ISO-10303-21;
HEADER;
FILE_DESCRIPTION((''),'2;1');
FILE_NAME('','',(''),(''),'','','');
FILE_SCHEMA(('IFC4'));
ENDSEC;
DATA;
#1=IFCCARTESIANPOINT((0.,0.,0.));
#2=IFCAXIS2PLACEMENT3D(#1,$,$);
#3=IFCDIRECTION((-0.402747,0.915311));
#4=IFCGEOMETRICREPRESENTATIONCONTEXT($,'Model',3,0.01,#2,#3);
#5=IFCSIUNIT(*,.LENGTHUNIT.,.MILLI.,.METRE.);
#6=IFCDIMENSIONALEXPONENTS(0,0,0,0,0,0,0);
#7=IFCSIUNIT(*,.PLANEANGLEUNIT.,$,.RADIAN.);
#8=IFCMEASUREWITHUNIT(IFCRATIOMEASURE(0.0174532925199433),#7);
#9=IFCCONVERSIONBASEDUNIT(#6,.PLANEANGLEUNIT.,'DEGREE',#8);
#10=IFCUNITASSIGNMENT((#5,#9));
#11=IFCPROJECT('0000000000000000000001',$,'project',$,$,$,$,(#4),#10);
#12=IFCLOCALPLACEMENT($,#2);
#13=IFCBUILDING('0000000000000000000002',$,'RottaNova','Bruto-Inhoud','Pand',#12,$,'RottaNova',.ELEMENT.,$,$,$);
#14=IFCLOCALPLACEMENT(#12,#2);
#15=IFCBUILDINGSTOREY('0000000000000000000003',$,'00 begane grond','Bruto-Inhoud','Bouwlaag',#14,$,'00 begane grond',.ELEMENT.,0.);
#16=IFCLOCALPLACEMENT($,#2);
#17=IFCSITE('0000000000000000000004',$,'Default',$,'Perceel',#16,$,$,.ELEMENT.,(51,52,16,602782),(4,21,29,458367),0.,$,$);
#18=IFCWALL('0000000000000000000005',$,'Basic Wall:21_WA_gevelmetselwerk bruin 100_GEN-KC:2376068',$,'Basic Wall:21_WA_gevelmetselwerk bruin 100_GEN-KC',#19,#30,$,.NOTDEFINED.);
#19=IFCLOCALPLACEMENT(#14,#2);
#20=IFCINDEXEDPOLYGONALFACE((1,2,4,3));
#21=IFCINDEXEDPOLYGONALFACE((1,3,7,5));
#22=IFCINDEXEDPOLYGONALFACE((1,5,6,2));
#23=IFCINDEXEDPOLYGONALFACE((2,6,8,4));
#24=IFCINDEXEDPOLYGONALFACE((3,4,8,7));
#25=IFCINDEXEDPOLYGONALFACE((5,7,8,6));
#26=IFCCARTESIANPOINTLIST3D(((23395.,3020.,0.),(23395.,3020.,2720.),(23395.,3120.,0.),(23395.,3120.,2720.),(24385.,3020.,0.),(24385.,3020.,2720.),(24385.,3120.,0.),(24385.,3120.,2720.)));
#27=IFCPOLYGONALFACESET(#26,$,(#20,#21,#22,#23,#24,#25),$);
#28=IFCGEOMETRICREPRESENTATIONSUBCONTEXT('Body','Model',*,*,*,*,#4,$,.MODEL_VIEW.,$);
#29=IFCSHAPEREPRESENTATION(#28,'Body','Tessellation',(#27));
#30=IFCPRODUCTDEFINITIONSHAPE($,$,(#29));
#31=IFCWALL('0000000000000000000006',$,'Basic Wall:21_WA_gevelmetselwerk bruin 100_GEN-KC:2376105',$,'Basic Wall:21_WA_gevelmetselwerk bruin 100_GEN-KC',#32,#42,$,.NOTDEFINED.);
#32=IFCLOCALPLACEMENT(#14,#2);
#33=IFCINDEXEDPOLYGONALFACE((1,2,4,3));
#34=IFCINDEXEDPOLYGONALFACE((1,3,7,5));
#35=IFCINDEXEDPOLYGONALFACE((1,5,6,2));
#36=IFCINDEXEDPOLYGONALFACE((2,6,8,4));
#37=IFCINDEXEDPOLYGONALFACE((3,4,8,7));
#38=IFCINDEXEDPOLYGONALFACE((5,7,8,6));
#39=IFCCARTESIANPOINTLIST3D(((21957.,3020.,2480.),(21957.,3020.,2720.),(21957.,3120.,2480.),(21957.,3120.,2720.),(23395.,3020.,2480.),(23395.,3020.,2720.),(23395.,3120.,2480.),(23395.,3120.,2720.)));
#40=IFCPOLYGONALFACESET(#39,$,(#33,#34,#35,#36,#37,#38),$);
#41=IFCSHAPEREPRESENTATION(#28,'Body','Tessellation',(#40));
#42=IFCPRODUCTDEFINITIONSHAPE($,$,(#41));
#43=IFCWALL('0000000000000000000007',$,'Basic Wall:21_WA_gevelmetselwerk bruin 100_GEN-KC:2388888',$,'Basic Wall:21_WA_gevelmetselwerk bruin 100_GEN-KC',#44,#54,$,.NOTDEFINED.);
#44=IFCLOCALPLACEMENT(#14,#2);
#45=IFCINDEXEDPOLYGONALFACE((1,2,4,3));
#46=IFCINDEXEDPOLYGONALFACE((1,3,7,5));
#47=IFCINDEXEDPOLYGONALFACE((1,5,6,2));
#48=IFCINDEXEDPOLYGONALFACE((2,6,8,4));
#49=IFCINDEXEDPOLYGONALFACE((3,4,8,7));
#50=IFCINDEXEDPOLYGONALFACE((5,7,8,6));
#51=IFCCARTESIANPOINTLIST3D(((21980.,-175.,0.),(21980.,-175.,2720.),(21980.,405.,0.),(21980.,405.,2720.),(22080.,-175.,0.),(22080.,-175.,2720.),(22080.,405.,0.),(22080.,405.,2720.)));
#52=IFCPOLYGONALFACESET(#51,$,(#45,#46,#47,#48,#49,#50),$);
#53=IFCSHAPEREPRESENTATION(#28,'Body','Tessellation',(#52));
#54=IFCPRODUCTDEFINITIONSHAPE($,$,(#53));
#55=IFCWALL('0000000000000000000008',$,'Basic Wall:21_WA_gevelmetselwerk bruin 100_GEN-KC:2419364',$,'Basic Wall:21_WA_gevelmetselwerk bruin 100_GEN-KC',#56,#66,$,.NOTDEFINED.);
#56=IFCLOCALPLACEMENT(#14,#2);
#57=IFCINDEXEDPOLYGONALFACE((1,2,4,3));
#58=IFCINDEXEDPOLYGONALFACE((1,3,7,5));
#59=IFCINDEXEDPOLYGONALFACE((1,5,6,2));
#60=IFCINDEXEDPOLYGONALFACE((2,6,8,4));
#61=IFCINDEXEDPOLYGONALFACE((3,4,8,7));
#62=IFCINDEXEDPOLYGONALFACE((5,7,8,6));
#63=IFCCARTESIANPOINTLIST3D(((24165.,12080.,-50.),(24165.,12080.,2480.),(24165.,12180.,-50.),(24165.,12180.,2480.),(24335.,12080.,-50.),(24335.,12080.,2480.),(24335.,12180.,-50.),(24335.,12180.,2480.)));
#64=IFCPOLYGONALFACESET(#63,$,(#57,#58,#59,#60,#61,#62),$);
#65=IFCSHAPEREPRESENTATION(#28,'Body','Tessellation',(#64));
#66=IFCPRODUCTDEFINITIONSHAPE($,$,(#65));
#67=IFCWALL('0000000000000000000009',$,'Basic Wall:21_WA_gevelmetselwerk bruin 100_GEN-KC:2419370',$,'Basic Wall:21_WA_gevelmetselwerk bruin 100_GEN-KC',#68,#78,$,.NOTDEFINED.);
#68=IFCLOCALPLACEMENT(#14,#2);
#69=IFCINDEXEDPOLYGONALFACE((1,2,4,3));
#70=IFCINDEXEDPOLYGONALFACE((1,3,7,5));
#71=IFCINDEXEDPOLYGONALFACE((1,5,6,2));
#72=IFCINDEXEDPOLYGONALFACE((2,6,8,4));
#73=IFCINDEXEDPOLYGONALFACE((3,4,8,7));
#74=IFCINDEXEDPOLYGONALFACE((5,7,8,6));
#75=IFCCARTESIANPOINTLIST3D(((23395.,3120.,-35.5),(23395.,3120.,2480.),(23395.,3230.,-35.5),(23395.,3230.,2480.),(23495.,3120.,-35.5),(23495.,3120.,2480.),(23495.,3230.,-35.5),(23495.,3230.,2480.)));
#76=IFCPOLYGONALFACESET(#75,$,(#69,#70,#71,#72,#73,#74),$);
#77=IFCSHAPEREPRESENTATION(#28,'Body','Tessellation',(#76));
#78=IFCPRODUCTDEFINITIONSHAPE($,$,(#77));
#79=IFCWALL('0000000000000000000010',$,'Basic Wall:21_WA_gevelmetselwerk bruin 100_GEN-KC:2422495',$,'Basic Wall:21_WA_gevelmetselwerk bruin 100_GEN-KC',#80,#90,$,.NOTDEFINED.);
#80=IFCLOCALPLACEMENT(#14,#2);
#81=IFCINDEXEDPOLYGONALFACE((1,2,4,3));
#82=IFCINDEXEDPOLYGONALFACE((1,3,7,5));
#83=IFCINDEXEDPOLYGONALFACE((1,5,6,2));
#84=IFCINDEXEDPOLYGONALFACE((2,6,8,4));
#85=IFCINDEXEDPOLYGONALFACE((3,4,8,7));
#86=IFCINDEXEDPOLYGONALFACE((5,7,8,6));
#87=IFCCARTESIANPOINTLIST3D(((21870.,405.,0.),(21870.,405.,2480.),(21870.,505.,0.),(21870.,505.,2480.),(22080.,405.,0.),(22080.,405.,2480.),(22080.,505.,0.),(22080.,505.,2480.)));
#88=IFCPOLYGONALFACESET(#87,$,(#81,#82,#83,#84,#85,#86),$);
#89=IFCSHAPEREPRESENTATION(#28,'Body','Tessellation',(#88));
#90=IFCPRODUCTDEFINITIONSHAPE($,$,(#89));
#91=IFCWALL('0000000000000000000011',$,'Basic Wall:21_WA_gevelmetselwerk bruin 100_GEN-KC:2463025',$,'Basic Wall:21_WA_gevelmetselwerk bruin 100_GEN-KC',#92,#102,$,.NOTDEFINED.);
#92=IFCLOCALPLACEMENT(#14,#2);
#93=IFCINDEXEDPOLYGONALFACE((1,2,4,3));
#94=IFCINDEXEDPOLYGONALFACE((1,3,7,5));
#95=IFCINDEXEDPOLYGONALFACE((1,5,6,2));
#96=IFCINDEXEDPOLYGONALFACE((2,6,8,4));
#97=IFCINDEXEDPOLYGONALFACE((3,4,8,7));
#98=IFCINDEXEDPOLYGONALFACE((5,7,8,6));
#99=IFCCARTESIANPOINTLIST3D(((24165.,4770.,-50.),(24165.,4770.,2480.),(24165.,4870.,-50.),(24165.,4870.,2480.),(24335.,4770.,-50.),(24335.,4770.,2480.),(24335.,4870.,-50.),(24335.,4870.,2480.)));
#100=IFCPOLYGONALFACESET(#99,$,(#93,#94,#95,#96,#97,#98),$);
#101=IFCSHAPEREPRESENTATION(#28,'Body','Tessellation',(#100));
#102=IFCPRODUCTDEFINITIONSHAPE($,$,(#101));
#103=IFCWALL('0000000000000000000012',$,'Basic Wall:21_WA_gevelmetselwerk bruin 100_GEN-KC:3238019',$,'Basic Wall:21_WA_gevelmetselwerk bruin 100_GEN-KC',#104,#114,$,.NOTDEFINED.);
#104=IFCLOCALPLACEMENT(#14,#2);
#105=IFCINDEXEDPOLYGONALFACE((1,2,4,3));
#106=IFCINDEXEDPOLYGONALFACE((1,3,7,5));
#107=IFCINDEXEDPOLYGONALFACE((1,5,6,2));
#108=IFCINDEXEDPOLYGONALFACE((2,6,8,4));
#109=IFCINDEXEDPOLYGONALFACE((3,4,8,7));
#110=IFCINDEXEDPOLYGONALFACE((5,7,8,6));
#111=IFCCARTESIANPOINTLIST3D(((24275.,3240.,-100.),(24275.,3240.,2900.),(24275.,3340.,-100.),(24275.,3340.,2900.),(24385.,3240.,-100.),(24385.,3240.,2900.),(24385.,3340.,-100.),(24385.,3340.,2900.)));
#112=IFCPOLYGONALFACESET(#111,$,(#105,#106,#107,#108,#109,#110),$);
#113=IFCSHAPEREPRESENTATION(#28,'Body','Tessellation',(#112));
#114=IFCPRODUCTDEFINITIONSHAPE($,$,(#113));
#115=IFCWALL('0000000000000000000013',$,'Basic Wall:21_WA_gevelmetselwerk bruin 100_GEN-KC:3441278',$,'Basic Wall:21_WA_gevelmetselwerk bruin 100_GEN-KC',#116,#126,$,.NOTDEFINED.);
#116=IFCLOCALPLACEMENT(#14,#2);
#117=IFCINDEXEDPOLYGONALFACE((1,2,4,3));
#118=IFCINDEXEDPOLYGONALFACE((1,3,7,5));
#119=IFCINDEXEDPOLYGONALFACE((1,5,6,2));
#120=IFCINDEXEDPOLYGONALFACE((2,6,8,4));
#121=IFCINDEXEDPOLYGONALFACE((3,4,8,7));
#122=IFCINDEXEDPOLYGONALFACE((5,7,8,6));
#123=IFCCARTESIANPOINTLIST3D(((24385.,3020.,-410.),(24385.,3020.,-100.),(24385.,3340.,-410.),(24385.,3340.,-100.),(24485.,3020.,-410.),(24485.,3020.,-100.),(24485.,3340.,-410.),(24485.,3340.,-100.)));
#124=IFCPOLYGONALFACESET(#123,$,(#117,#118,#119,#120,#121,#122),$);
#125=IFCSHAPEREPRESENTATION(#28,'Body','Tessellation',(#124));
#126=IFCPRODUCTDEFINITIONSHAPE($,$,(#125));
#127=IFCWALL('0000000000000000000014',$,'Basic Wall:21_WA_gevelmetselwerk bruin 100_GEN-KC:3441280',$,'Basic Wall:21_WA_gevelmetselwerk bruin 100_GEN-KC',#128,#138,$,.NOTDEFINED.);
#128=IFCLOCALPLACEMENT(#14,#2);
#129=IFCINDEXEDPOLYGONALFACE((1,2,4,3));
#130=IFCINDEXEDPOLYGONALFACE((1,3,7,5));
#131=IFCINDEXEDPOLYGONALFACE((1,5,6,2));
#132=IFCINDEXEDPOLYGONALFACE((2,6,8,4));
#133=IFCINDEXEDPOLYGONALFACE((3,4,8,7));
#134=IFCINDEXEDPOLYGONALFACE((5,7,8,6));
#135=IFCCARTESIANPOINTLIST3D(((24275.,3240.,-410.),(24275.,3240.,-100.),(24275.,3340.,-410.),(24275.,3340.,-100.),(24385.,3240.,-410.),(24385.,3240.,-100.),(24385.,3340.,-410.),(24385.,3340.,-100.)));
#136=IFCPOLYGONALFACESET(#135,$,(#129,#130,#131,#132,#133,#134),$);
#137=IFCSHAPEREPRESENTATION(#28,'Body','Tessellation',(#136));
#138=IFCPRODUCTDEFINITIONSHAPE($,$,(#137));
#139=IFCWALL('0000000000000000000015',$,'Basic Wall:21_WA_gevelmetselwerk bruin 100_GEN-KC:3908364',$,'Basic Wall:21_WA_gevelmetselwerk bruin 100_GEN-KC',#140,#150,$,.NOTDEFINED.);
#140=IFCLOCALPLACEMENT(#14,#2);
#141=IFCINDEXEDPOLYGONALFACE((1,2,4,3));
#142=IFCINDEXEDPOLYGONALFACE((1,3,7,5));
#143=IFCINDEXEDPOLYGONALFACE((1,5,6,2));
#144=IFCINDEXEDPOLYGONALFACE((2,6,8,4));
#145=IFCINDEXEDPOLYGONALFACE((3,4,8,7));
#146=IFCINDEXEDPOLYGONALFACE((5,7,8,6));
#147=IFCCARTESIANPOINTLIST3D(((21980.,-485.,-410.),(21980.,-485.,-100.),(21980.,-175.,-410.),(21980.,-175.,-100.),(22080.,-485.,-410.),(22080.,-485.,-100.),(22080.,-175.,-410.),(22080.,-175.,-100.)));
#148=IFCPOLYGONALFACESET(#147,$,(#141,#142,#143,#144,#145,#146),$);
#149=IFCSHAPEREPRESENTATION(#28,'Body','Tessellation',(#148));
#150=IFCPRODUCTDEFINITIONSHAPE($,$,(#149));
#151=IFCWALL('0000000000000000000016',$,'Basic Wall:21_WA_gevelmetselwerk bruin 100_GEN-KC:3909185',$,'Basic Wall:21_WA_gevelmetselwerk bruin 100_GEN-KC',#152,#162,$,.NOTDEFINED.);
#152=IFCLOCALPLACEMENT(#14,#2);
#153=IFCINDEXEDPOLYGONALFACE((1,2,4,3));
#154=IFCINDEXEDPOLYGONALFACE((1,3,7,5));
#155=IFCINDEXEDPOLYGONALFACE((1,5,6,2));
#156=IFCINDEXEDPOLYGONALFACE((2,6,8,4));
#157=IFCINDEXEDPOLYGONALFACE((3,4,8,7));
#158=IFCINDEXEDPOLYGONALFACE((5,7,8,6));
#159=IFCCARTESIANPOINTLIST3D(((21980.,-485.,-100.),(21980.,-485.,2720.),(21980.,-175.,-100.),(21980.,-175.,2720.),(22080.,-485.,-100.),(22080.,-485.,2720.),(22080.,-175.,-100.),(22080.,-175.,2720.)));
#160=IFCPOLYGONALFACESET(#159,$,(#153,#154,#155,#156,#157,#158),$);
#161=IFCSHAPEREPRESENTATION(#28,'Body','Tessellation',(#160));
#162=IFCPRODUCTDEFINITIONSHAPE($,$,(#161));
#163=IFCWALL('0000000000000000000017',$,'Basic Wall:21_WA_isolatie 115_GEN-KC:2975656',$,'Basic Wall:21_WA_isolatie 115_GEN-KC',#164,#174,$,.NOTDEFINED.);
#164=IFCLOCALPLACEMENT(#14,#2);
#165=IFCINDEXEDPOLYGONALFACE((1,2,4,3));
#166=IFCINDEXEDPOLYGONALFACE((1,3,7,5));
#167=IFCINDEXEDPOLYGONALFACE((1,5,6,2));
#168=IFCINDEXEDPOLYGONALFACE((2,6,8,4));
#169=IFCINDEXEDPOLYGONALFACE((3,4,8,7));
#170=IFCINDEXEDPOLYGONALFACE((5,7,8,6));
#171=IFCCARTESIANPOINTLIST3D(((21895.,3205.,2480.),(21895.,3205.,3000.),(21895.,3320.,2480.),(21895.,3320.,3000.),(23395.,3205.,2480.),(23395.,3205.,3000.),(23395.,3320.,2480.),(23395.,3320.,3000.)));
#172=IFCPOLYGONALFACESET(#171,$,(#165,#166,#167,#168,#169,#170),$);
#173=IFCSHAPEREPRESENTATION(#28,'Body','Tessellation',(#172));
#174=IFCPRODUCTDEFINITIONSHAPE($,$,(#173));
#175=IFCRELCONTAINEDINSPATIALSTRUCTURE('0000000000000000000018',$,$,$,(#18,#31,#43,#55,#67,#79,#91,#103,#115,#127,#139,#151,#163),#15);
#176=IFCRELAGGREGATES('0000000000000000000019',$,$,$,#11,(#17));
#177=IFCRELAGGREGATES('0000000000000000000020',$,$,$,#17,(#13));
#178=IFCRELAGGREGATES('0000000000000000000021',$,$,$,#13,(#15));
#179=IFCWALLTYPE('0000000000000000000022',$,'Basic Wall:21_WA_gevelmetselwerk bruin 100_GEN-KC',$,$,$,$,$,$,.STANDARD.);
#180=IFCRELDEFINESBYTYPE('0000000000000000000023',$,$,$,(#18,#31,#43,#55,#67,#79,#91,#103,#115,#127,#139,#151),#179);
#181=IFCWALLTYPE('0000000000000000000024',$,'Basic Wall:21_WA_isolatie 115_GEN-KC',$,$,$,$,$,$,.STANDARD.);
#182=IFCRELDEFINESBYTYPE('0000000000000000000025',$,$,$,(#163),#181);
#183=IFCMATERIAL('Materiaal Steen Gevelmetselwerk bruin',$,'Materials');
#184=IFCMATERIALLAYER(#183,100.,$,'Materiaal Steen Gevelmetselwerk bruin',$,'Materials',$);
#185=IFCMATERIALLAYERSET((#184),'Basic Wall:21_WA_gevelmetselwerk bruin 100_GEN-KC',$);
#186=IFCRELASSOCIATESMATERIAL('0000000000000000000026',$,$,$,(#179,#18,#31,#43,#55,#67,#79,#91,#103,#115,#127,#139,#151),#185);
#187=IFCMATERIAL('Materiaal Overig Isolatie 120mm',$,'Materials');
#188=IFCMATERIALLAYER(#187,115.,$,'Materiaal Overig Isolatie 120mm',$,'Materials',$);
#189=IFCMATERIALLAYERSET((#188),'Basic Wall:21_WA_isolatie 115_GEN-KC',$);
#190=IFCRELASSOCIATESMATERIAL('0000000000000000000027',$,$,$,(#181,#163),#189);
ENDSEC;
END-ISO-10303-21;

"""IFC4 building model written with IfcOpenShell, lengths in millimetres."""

from ifc_helpers import new_model, entity, si_unit, converted_unit, direction, frame, frame_2d, origin, place, context, subcontext, project, spatial, rectangle, extrude, material, layer, layer_set, type_object, element, save


model = new_model("IFC4")

# Units and contexts
model_context = context("Model", 3, precision=0.01, world=origin(), true_north=direction((-0.402747, 0.915311)))
body_context = subcontext(model_context, "Body", "Model", "MODEL_VIEW")
ifc_project = project(units=[si_unit("LENGTHUNIT", "METRE", prefix="MILLI"), converted_unit("PLANEANGLEUNIT", "DEGREE", entity("IfcRatioMeasure", 0.0174532925199433), si_unit("PLANEANGLEUNIT", "RADIAN"), dimensions=[0, 0, 0, 0, 0, 0, 0])], contexts=[model_context])

# Site, building, storey
site_placement = place(None, origin())
site = spatial("IfcSite", under=ifc_project, at=site_placement, Name="Default", ObjectType="Perceel", CompositionType="ELEMENT", RefLatitude=(51, 52, 16, 602782), RefLongitude=(4, 21, 29, 458367), RefElevation=0.0)
building_placement = place(None, origin())
building = spatial("IfcBuilding", under=site, at=building_placement, Name="RottaNova", Description="Bruto-Inhoud", ObjectType="Pand", LongName="RottaNova", CompositionType="ELEMENT")
storey_placement = place(building_placement, origin())
storey = spatial("IfcBuildingStorey", under=building, at=storey_placement, Name="00 begane grond", Description="Bruto-Inhoud", ObjectType="Bouwlaag", LongName="00 begane grond", CompositionType="ELEMENT", Elevation=0.0)

# Walls
ifc_material_1 = material(Name="Materiaal Steen Gevelmetselwerk bruin", Category="Materials")
ifc_layer_1 = layer(ifc_material_1, 100.0, Name="Materiaal Steen Gevelmetselwerk bruin", Category="Materials")
ifc_layer_set_1 = layer_set([ifc_layer_1], Name="Basic Wall:21_WA_gevelmetselwerk bruin 100_GEN-KC")
wall_type_1 = type_object("IfcWallType", Name="Basic Wall:21_WA_gevelmetselwerk bruin 100_GEN-KC", PredefinedType="STANDARD", material=ifc_layer_set_1)
wall_1_placement = place(storey_placement, frame((23395.0, 3070.0, 0.0)))
element("IfcWall", 1, at=wall_1_placement, inside=storey, type_object=wall_type_1, material=ifc_layer_set_1, Name="Basic Wall:21_WA_gevelmetselwerk bruin 100_GEN-KC:2376068", ObjectType="Basic Wall:21_WA_gevelmetselwerk bruin 100_GEN-KC", PredefinedType="NOTDEFINED", context=body_context, shape_type="SweptSolid", body=[
    extrude(rectangle(XDim=990.0, YDim=100.0, at=frame_2d((495.0, 0.0), x_axis=(-1.0, 0.0))), origin(), (0.0, 0.0, 1.0), 2720.0),
])
wall_2_placement = place(storey_placement, frame((23395.0, 3070.0, 2480.0), z_axis=(0.0, 0.0, 1.0), x_axis=(-1.0, 0.0, 0.0)))
element("IfcWall", 2, at=wall_2_placement, inside=storey, type_object=wall_type_1, material=ifc_layer_set_1, Name="Basic Wall:21_WA_gevelmetselwerk bruin 100_GEN-KC:2376105", ObjectType="Basic Wall:21_WA_gevelmetselwerk bruin 100_GEN-KC", PredefinedType="NOTDEFINED", context=body_context, shape_type="SweptSolid", body=[
    extrude(rectangle(XDim=1438.0, YDim=100.0, at=frame_2d((719.0, 0.0), x_axis=(-1.0, 0.0))), origin(), (0.0, 0.0, 1.0), 240.0),
])
wall_3_placement = place(storey_placement, frame((22030.0, 405.0, 0.0), z_axis=(0.0, 0.0, 1.0), x_axis=(0.0, -1.0, 0.0)))
element("IfcWall", 3, at=wall_3_placement, inside=storey, type_object=wall_type_1, material=ifc_layer_set_1, Name="Basic Wall:21_WA_gevelmetselwerk bruin 100_GEN-KC:2388888", ObjectType="Basic Wall:21_WA_gevelmetselwerk bruin 100_GEN-KC", PredefinedType="NOTDEFINED", context=body_context, shape_type="SweptSolid", body=[
    extrude(rectangle(XDim=580.0, YDim=100.0, at=frame_2d((290.0, 0.0), x_axis=(-1.0, 0.0))), origin(), (0.0, 0.0, 1.0), 2720.0),
])
wall_4_placement = place(storey_placement, frame((24335.0, 12130.0, -50.0), z_axis=(0.0, 0.0, 1.0), x_axis=(-1.0, 0.0, 0.0)))
element("IfcWall", 4, at=wall_4_placement, inside=storey, type_object=wall_type_1, material=ifc_layer_set_1, Name="Basic Wall:21_WA_gevelmetselwerk bruin 100_GEN-KC:2419364", ObjectType="Basic Wall:21_WA_gevelmetselwerk bruin 100_GEN-KC", PredefinedType="NOTDEFINED", context=body_context, shape_type="SweptSolid", body=[
    extrude(rectangle(XDim=170.0, YDim=100.0, at=frame_2d((85.0, 0.0), x_axis=(-1.0, 0.0))), origin(), (0.0, 0.0, 1.0), 2530.0),
])
wall_5_placement = place(storey_placement, frame((23445.0, 3230.0, -35.5), z_axis=(0.0, 0.0, 1.0), x_axis=(0.0, -1.0, 0.0)))
element("IfcWall", 5, at=wall_5_placement, inside=storey, type_object=wall_type_1, material=ifc_layer_set_1, Name="Basic Wall:21_WA_gevelmetselwerk bruin 100_GEN-KC:2419370", ObjectType="Basic Wall:21_WA_gevelmetselwerk bruin 100_GEN-KC", PredefinedType="NOTDEFINED", context=body_context, shape_type="SweptSolid", body=[
    extrude(rectangle(XDim=110.0, YDim=100.0, at=frame_2d((55.0, 0.0), x_axis=(-1.0, 0.0))), origin(), (0.0, 0.0, 1.0), 2515.5),
])
wall_6_placement = place(storey_placement, frame((21870.0, 455.0, 0.0)))
element("IfcWall", 6, at=wall_6_placement, inside=storey, type_object=wall_type_1, material=ifc_layer_set_1, Name="Basic Wall:21_WA_gevelmetselwerk bruin 100_GEN-KC:2422495", ObjectType="Basic Wall:21_WA_gevelmetselwerk bruin 100_GEN-KC", PredefinedType="NOTDEFINED", context=body_context, shape_type="SweptSolid", body=[
    extrude(rectangle(XDim=210.0, YDim=100.0, at=frame_2d((105.0, 0.0), x_axis=(-1.0, 0.0))), origin(), (0.0, 0.0, 1.0), 2480.0),
])
wall_7_placement = place(storey_placement, frame((24335.0, 4820.0, -50.0), z_axis=(0.0, 0.0, 1.0), x_axis=(-1.0, 0.0, 0.0)))
element("IfcWall", 7, at=wall_7_placement, inside=storey, type_object=wall_type_1, material=ifc_layer_set_1, Name="Basic Wall:21_WA_gevelmetselwerk bruin 100_GEN-KC:2463025", ObjectType="Basic Wall:21_WA_gevelmetselwerk bruin 100_GEN-KC", PredefinedType="NOTDEFINED", context=body_context, shape_type="SweptSolid", body=[
    extrude(rectangle(XDim=170.0, YDim=100.0, at=frame_2d((85.0, 0.0), x_axis=(-1.0, 0.0))), origin(), (0.0, 0.0, 1.0), 2530.0),
])
wall_8_placement = place(storey_placement, frame((24385.0, 3290.0, -100.0), z_axis=(0.0, 0.0, 1.0), x_axis=(-1.0, 0.0, 0.0)))
element("IfcWall", 8, at=wall_8_placement, inside=storey, type_object=wall_type_1, material=ifc_layer_set_1, Name="Basic Wall:21_WA_gevelmetselwerk bruin 100_GEN-KC:3238019", ObjectType="Basic Wall:21_WA_gevelmetselwerk bruin 100_GEN-KC", PredefinedType="NOTDEFINED", context=body_context, shape_type="SweptSolid", body=[
    extrude(rectangle(XDim=110.0, YDim=100.0, at=frame_2d((55.0, 0.0), x_axis=(-1.0, 0.0))), origin(), (0.0, 0.0, 1.0), 3000.0),
])
wall_9_placement = place(storey_placement, frame((24435.0, 3340.0, -410.0), z_axis=(0.0, 0.0, 1.0), x_axis=(0.0, -1.0, 0.0)))
element("IfcWall", 9, at=wall_9_placement, inside=storey, type_object=wall_type_1, material=ifc_layer_set_1, Name="Basic Wall:21_WA_gevelmetselwerk bruin 100_GEN-KC:3441278", ObjectType="Basic Wall:21_WA_gevelmetselwerk bruin 100_GEN-KC", PredefinedType="NOTDEFINED", context=body_context, shape_type="SweptSolid", body=[
    extrude(rectangle(XDim=320.0, YDim=100.0, at=frame_2d((160.0, 0.0), x_axis=(-1.0, 0.0))), origin(), (0.0, 0.0, 1.0), 310.0),
])
wall_10_placement = place(storey_placement, frame((24385.0, 3290.0, -410.0), z_axis=(0.0, 0.0, 1.0), x_axis=(-1.0, 0.0, 0.0)))
element("IfcWall", 10, at=wall_10_placement, inside=storey, type_object=wall_type_1, material=ifc_layer_set_1, Name="Basic Wall:21_WA_gevelmetselwerk bruin 100_GEN-KC:3441280", ObjectType="Basic Wall:21_WA_gevelmetselwerk bruin 100_GEN-KC", PredefinedType="NOTDEFINED", context=body_context, shape_type="SweptSolid", body=[
    extrude(rectangle(XDim=110.0, YDim=100.0, at=frame_2d((55.0, 0.0), x_axis=(-1.0, 0.0))), origin(), (0.0, 0.0, 1.0), 310.0),
])
wall_11_placement = place(storey_placement, frame((22030.0, -175.0, -410.0), z_axis=(0.0, 0.0, 1.0), x_axis=(0.0, -1.0, 0.0)))
element("IfcWall", 11, at=wall_11_placement, inside=storey, type_object=wall_type_1, material=ifc_layer_set_1, Name="Basic Wall:21_WA_gevelmetselwerk bruin 100_GEN-KC:3908364", ObjectType="Basic Wall:21_WA_gevelmetselwerk bruin 100_GEN-KC", PredefinedType="NOTDEFINED", context=body_context, shape_type="SweptSolid", body=[
    extrude(rectangle(XDim=310.0, YDim=100.0, at=frame_2d((155.0, 0.0), x_axis=(-1.0, 0.0))), origin(), (0.0, 0.0, 1.0), 310.0),
])
wall_12_placement = place(storey_placement, frame((22030.0, -175.0, -100.0), z_axis=(0.0, 0.0, 1.0), x_axis=(0.0, -1.0, 0.0)))
element("IfcWall", 12, at=wall_12_placement, inside=storey, type_object=wall_type_1, material=ifc_layer_set_1, Name="Basic Wall:21_WA_gevelmetselwerk bruin 100_GEN-KC:3909185", ObjectType="Basic Wall:21_WA_gevelmetselwerk bruin 100_GEN-KC", PredefinedType="NOTDEFINED", context=body_context, shape_type="SweptSolid", body=[
    extrude(rectangle(XDim=310.0, YDim=100.0, at=frame_2d((155.0, 0.0), x_axis=(-1.0, 0.0))), origin(), (0.0, 0.0, 1.0), 2820.0),
])
ifc_material_2 = material(Name="Materiaal Overig Isolatie 120mm", Category="Materials")
ifc_layer_2 = layer(ifc_material_2, 115.0, Name="Materiaal Overig Isolatie 120mm", Category="Materials")
ifc_layer_set_2 = layer_set([ifc_layer_2], Name="Basic Wall:21_WA_isolatie 115_GEN-KC")
wall_type_2 = type_object("IfcWallType", Name="Basic Wall:21_WA_isolatie 115_GEN-KC", PredefinedType="STANDARD", material=ifc_layer_set_2)
wall_13_placement = place(storey_placement, frame((23395.0, 3262.5, 2480.0), z_axis=(0.0, 0.0, 1.0), x_axis=(-1.0, 0.0, 0.0)))
element("IfcWall", 13, at=wall_13_placement, inside=storey, type_object=wall_type_2, material=ifc_layer_set_2, Name="Basic Wall:21_WA_isolatie 115_GEN-KC:2975656", ObjectType="Basic Wall:21_WA_isolatie 115_GEN-KC", PredefinedType="NOTDEFINED", context=body_context, shape_type="SweptSolid", body=[
    extrude(rectangle(XDim=1500.0, YDim=115.0, at=frame_2d((750.0, 0.0), x_axis=(1.0, 0.0))), origin(), (0.0, 0.0, 1.0), 520.0),
])

save(model, "model.ifc")
